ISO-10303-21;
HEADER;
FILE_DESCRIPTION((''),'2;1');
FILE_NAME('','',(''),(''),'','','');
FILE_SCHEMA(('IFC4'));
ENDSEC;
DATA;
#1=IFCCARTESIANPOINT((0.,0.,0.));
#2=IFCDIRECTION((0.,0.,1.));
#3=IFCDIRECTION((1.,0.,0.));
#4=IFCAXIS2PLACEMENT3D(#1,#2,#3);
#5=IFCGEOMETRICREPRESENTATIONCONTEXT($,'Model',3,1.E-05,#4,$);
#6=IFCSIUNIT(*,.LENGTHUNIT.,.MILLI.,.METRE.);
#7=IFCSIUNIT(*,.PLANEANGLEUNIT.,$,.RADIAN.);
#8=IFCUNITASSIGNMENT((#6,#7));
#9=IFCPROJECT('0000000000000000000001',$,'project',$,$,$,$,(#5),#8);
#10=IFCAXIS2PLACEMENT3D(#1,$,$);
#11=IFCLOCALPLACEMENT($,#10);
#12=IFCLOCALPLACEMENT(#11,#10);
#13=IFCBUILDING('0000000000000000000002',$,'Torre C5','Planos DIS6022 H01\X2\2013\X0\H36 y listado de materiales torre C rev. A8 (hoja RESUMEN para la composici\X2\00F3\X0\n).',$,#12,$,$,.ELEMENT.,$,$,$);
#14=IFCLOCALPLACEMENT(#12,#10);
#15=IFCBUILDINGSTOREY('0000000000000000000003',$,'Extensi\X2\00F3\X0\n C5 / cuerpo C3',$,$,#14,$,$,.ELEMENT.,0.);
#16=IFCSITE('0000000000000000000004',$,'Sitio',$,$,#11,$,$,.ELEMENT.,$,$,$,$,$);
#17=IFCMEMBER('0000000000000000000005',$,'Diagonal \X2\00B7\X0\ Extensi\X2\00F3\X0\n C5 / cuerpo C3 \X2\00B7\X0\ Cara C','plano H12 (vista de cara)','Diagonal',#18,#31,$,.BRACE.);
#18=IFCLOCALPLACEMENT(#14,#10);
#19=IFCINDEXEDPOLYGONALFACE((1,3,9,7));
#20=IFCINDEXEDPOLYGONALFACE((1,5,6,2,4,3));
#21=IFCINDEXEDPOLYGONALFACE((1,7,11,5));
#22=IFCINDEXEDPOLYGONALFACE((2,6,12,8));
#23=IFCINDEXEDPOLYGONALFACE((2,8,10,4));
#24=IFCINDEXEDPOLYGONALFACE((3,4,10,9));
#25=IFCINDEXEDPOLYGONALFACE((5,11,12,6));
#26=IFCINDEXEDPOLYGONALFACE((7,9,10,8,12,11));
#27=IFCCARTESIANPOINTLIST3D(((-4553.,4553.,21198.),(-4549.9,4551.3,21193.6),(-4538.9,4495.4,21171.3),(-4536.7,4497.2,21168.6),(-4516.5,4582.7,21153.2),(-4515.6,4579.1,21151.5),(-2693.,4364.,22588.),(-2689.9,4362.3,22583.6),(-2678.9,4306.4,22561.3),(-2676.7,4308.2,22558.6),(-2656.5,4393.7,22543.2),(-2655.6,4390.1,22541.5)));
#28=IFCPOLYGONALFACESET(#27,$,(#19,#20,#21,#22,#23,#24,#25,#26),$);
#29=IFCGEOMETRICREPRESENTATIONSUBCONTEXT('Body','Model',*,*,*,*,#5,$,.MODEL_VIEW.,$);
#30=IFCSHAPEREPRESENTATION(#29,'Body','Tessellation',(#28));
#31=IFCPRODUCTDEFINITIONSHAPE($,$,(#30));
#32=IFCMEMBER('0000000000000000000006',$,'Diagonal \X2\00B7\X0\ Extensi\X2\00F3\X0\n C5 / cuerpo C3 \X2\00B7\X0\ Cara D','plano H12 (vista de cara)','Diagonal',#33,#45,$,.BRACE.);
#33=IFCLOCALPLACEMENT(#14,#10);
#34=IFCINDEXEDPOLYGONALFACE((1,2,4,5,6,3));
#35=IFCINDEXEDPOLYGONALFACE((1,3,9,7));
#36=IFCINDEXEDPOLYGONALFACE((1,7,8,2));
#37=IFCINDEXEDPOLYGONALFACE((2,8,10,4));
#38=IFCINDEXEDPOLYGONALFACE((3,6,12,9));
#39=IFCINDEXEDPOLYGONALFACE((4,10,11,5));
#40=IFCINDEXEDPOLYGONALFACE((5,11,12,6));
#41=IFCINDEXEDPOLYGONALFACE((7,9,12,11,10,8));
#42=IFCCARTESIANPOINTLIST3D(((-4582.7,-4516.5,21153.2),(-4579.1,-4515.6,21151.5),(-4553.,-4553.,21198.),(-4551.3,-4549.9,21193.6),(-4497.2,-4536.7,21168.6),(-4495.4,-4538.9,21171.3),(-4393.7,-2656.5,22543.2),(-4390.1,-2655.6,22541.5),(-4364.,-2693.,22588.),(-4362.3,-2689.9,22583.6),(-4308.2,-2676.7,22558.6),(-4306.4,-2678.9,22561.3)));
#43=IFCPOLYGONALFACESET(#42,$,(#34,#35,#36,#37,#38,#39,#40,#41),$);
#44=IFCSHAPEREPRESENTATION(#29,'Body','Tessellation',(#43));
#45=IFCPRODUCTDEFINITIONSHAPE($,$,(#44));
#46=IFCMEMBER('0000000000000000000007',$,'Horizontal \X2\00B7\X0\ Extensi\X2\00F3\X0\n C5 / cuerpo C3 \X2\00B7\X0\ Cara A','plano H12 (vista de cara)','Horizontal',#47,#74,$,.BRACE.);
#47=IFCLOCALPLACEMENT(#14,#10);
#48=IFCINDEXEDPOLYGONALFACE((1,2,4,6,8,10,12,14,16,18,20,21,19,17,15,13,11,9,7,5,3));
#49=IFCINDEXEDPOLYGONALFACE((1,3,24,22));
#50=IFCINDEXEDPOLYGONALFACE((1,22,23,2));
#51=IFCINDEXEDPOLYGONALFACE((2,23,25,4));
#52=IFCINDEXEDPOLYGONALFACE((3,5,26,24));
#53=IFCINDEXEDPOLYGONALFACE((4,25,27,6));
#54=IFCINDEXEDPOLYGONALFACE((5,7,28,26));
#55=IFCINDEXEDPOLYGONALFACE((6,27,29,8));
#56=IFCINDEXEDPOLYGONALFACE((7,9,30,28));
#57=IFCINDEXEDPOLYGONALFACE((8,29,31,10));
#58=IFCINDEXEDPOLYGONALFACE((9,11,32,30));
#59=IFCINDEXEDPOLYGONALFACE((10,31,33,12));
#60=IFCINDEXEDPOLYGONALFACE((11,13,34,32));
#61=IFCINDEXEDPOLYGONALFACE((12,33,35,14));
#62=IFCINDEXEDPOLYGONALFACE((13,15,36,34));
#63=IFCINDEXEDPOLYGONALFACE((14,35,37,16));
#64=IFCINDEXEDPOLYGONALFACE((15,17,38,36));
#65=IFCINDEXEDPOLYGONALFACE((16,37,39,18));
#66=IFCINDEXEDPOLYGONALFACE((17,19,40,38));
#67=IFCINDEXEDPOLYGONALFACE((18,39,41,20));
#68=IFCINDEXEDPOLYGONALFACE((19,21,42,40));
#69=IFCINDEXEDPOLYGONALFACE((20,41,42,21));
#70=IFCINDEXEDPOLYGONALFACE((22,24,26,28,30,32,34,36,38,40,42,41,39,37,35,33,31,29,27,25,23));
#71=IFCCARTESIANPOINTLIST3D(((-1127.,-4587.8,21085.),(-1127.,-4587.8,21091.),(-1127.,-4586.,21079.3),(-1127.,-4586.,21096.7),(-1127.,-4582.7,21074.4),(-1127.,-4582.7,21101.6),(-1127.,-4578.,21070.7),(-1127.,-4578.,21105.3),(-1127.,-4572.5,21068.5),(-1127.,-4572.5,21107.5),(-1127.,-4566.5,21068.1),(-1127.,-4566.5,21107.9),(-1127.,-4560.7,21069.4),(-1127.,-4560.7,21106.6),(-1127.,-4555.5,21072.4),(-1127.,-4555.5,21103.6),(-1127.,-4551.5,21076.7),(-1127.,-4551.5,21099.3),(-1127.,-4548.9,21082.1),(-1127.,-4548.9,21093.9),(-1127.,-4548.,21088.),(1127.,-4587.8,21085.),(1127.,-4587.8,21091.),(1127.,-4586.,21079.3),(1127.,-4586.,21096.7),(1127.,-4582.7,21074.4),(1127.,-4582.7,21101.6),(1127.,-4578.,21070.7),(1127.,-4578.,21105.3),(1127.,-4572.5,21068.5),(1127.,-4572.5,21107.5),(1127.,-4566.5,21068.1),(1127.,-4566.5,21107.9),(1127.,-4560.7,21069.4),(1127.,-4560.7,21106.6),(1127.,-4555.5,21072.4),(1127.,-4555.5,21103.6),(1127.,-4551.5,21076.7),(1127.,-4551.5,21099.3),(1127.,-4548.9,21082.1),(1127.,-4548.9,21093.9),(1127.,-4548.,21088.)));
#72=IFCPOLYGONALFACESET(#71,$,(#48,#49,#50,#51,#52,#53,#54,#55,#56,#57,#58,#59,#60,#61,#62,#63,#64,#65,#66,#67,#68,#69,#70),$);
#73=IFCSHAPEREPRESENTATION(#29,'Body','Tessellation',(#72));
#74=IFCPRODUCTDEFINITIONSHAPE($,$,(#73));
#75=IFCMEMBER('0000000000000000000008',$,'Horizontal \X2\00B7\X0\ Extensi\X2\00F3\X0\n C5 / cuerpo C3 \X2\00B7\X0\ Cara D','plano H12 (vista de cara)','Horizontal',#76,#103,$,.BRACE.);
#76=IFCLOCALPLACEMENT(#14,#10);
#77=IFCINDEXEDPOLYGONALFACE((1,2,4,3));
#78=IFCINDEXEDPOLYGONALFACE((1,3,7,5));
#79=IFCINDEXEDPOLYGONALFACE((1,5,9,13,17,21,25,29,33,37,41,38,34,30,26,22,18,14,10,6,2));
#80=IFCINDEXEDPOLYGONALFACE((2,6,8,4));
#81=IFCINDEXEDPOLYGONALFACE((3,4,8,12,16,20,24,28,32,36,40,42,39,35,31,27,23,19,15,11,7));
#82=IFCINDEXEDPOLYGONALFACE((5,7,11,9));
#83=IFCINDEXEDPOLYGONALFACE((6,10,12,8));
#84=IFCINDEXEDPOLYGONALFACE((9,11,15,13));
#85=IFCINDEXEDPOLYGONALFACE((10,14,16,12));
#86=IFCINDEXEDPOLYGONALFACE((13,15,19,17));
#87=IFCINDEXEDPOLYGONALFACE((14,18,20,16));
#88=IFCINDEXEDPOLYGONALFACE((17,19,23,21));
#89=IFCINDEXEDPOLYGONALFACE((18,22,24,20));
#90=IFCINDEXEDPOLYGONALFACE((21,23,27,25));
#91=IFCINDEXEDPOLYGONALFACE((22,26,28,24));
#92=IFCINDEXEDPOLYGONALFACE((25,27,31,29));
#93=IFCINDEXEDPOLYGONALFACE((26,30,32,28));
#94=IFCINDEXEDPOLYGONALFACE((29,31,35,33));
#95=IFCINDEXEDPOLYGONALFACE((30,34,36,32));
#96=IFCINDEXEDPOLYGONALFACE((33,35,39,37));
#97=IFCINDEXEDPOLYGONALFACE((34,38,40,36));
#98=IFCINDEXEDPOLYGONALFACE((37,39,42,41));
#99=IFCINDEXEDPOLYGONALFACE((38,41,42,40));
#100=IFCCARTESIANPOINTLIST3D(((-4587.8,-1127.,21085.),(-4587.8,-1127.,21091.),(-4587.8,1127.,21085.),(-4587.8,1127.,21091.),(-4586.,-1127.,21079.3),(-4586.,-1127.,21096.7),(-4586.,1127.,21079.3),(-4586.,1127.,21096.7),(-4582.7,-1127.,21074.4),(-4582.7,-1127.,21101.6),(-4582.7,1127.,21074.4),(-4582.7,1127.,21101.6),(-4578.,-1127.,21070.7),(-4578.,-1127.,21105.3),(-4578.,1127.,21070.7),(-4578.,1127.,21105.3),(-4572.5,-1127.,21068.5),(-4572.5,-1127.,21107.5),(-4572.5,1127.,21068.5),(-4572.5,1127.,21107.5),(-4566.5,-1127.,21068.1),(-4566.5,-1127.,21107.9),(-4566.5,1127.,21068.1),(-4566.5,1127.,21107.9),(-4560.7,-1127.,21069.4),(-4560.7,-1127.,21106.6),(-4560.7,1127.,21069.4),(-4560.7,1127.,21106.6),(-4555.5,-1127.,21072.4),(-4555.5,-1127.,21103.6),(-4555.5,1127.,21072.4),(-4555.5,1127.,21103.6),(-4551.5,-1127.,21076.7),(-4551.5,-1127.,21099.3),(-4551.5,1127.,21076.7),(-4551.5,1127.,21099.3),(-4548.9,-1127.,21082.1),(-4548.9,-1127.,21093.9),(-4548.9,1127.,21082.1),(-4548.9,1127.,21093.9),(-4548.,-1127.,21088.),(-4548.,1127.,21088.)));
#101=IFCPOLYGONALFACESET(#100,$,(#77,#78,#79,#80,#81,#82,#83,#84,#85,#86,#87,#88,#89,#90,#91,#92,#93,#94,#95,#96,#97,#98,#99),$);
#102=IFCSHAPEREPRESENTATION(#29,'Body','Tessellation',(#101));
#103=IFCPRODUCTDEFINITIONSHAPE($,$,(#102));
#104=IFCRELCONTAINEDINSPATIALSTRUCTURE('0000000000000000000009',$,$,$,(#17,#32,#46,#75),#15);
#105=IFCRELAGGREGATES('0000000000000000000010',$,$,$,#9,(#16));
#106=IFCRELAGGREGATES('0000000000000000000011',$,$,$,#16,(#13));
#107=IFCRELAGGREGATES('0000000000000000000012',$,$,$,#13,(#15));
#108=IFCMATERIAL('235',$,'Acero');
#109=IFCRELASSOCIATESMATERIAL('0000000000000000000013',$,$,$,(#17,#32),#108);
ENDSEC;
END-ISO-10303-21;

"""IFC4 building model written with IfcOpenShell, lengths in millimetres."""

from ifc_helpers import new_model, si_unit, frame, frame_2d, origin, origin_with_axes, place, context, subcontext, project, spatial, circle, l_section, extrude, material, element, save


model = new_model("IFC4")

# Units and contexts
model_context = context("Model", 3, precision=1e-05, world=origin_with_axes())
body_context = subcontext(model_context, "Body", "Model", "MODEL_VIEW")
ifc_project = project(units=[si_unit("LENGTHUNIT", "METRE", prefix="MILLI"), si_unit("PLANEANGLEUNIT", "RADIAN")], contexts=[model_context])

# Site, building, storey
site_placement = place(None, origin())
site = spatial("IfcSite", under=ifc_project, at=site_placement, Name="Sitio", CompositionType="ELEMENT")
building_placement = place(site_placement, origin())
building = spatial("IfcBuilding", under=site, at=building_placement, Name="Torre C5", Description="Planos DIS6022 H01–H36 y listado de materiales torre C rev. A8 (hoja RESUMEN para la composición).", CompositionType="ELEMENT")
storey_placement = place(building_placement, origin())
storey = spatial("IfcBuildingStorey", under=building, at=storey_placement, Name="Extensión C5 / cuerpo C3", CompositionType="ELEMENT", Elevation=0.0)

# Members
ifc_material_1 = material(Name="235", Category="Acero")
for number, where, z_axis, x_axis, name in (
    (1, (-4553.0, 4553.0, 21198.0), (0.798392, -0.081127, 0.596648), (0.216463, -0.885971, -0.410122), "Diagonal · Extensión C5 / cuerpo C3 · Cara C"),
    (2, (-4553.0, -4553.0, 21198.0), (0.081127, 0.798392, 0.596648), (0.885971, 0.216463, -0.410122), "Diagonal · Extensión C5 / cuerpo C3 · Cara D"),
):
    element("IfcMember", number, at=place(storey_placement, frame(where, z_axis=z_axis, x_axis=x_axis)), inside=storey, material=ifc_material_1, Name=name, Description="plano H12 (vista de cara)", ObjectType="Diagonal", PredefinedType="BRACE", context=body_context, shape_type="SweptSolid", body=[
        extrude(l_section(Depth=65.0, Width=65.0, Thickness=4.0, at=frame_2d((32.5, 32.5))), None, (0.0, 0.0, 1.0), 2329.7),
    ])
for number, where, z_axis, x_axis, name in (
    (3, (-1127.0, -4568.0, 21088.0), (1.0, 0.0, 0.0), (0.0, 1.0, 0.0), "Horizontal · Extensión C5 / cuerpo C3 · Cara A"),
    (4, (-4568.0, 1127.0, 21088.0), (0.0, -1.0, 0.0), (1.0, 0.0, 0.0), "Horizontal · Extensión C5 / cuerpo C3 · Cara D"),
):
    element("IfcMember", number, at=place(storey_placement, frame(where, z_axis=z_axis, x_axis=x_axis)), inside=storey, Name=name, Description="plano H12 (vista de cara)", ObjectType="Horizontal", PredefinedType="BRACE", context=body_context, shape_type="SweptSolid", body=[
        extrude(circle(Radius=20.0), None, (0.0, 0.0, 1.0), 2254.0),
    ])

save(model, "model.ifc")
